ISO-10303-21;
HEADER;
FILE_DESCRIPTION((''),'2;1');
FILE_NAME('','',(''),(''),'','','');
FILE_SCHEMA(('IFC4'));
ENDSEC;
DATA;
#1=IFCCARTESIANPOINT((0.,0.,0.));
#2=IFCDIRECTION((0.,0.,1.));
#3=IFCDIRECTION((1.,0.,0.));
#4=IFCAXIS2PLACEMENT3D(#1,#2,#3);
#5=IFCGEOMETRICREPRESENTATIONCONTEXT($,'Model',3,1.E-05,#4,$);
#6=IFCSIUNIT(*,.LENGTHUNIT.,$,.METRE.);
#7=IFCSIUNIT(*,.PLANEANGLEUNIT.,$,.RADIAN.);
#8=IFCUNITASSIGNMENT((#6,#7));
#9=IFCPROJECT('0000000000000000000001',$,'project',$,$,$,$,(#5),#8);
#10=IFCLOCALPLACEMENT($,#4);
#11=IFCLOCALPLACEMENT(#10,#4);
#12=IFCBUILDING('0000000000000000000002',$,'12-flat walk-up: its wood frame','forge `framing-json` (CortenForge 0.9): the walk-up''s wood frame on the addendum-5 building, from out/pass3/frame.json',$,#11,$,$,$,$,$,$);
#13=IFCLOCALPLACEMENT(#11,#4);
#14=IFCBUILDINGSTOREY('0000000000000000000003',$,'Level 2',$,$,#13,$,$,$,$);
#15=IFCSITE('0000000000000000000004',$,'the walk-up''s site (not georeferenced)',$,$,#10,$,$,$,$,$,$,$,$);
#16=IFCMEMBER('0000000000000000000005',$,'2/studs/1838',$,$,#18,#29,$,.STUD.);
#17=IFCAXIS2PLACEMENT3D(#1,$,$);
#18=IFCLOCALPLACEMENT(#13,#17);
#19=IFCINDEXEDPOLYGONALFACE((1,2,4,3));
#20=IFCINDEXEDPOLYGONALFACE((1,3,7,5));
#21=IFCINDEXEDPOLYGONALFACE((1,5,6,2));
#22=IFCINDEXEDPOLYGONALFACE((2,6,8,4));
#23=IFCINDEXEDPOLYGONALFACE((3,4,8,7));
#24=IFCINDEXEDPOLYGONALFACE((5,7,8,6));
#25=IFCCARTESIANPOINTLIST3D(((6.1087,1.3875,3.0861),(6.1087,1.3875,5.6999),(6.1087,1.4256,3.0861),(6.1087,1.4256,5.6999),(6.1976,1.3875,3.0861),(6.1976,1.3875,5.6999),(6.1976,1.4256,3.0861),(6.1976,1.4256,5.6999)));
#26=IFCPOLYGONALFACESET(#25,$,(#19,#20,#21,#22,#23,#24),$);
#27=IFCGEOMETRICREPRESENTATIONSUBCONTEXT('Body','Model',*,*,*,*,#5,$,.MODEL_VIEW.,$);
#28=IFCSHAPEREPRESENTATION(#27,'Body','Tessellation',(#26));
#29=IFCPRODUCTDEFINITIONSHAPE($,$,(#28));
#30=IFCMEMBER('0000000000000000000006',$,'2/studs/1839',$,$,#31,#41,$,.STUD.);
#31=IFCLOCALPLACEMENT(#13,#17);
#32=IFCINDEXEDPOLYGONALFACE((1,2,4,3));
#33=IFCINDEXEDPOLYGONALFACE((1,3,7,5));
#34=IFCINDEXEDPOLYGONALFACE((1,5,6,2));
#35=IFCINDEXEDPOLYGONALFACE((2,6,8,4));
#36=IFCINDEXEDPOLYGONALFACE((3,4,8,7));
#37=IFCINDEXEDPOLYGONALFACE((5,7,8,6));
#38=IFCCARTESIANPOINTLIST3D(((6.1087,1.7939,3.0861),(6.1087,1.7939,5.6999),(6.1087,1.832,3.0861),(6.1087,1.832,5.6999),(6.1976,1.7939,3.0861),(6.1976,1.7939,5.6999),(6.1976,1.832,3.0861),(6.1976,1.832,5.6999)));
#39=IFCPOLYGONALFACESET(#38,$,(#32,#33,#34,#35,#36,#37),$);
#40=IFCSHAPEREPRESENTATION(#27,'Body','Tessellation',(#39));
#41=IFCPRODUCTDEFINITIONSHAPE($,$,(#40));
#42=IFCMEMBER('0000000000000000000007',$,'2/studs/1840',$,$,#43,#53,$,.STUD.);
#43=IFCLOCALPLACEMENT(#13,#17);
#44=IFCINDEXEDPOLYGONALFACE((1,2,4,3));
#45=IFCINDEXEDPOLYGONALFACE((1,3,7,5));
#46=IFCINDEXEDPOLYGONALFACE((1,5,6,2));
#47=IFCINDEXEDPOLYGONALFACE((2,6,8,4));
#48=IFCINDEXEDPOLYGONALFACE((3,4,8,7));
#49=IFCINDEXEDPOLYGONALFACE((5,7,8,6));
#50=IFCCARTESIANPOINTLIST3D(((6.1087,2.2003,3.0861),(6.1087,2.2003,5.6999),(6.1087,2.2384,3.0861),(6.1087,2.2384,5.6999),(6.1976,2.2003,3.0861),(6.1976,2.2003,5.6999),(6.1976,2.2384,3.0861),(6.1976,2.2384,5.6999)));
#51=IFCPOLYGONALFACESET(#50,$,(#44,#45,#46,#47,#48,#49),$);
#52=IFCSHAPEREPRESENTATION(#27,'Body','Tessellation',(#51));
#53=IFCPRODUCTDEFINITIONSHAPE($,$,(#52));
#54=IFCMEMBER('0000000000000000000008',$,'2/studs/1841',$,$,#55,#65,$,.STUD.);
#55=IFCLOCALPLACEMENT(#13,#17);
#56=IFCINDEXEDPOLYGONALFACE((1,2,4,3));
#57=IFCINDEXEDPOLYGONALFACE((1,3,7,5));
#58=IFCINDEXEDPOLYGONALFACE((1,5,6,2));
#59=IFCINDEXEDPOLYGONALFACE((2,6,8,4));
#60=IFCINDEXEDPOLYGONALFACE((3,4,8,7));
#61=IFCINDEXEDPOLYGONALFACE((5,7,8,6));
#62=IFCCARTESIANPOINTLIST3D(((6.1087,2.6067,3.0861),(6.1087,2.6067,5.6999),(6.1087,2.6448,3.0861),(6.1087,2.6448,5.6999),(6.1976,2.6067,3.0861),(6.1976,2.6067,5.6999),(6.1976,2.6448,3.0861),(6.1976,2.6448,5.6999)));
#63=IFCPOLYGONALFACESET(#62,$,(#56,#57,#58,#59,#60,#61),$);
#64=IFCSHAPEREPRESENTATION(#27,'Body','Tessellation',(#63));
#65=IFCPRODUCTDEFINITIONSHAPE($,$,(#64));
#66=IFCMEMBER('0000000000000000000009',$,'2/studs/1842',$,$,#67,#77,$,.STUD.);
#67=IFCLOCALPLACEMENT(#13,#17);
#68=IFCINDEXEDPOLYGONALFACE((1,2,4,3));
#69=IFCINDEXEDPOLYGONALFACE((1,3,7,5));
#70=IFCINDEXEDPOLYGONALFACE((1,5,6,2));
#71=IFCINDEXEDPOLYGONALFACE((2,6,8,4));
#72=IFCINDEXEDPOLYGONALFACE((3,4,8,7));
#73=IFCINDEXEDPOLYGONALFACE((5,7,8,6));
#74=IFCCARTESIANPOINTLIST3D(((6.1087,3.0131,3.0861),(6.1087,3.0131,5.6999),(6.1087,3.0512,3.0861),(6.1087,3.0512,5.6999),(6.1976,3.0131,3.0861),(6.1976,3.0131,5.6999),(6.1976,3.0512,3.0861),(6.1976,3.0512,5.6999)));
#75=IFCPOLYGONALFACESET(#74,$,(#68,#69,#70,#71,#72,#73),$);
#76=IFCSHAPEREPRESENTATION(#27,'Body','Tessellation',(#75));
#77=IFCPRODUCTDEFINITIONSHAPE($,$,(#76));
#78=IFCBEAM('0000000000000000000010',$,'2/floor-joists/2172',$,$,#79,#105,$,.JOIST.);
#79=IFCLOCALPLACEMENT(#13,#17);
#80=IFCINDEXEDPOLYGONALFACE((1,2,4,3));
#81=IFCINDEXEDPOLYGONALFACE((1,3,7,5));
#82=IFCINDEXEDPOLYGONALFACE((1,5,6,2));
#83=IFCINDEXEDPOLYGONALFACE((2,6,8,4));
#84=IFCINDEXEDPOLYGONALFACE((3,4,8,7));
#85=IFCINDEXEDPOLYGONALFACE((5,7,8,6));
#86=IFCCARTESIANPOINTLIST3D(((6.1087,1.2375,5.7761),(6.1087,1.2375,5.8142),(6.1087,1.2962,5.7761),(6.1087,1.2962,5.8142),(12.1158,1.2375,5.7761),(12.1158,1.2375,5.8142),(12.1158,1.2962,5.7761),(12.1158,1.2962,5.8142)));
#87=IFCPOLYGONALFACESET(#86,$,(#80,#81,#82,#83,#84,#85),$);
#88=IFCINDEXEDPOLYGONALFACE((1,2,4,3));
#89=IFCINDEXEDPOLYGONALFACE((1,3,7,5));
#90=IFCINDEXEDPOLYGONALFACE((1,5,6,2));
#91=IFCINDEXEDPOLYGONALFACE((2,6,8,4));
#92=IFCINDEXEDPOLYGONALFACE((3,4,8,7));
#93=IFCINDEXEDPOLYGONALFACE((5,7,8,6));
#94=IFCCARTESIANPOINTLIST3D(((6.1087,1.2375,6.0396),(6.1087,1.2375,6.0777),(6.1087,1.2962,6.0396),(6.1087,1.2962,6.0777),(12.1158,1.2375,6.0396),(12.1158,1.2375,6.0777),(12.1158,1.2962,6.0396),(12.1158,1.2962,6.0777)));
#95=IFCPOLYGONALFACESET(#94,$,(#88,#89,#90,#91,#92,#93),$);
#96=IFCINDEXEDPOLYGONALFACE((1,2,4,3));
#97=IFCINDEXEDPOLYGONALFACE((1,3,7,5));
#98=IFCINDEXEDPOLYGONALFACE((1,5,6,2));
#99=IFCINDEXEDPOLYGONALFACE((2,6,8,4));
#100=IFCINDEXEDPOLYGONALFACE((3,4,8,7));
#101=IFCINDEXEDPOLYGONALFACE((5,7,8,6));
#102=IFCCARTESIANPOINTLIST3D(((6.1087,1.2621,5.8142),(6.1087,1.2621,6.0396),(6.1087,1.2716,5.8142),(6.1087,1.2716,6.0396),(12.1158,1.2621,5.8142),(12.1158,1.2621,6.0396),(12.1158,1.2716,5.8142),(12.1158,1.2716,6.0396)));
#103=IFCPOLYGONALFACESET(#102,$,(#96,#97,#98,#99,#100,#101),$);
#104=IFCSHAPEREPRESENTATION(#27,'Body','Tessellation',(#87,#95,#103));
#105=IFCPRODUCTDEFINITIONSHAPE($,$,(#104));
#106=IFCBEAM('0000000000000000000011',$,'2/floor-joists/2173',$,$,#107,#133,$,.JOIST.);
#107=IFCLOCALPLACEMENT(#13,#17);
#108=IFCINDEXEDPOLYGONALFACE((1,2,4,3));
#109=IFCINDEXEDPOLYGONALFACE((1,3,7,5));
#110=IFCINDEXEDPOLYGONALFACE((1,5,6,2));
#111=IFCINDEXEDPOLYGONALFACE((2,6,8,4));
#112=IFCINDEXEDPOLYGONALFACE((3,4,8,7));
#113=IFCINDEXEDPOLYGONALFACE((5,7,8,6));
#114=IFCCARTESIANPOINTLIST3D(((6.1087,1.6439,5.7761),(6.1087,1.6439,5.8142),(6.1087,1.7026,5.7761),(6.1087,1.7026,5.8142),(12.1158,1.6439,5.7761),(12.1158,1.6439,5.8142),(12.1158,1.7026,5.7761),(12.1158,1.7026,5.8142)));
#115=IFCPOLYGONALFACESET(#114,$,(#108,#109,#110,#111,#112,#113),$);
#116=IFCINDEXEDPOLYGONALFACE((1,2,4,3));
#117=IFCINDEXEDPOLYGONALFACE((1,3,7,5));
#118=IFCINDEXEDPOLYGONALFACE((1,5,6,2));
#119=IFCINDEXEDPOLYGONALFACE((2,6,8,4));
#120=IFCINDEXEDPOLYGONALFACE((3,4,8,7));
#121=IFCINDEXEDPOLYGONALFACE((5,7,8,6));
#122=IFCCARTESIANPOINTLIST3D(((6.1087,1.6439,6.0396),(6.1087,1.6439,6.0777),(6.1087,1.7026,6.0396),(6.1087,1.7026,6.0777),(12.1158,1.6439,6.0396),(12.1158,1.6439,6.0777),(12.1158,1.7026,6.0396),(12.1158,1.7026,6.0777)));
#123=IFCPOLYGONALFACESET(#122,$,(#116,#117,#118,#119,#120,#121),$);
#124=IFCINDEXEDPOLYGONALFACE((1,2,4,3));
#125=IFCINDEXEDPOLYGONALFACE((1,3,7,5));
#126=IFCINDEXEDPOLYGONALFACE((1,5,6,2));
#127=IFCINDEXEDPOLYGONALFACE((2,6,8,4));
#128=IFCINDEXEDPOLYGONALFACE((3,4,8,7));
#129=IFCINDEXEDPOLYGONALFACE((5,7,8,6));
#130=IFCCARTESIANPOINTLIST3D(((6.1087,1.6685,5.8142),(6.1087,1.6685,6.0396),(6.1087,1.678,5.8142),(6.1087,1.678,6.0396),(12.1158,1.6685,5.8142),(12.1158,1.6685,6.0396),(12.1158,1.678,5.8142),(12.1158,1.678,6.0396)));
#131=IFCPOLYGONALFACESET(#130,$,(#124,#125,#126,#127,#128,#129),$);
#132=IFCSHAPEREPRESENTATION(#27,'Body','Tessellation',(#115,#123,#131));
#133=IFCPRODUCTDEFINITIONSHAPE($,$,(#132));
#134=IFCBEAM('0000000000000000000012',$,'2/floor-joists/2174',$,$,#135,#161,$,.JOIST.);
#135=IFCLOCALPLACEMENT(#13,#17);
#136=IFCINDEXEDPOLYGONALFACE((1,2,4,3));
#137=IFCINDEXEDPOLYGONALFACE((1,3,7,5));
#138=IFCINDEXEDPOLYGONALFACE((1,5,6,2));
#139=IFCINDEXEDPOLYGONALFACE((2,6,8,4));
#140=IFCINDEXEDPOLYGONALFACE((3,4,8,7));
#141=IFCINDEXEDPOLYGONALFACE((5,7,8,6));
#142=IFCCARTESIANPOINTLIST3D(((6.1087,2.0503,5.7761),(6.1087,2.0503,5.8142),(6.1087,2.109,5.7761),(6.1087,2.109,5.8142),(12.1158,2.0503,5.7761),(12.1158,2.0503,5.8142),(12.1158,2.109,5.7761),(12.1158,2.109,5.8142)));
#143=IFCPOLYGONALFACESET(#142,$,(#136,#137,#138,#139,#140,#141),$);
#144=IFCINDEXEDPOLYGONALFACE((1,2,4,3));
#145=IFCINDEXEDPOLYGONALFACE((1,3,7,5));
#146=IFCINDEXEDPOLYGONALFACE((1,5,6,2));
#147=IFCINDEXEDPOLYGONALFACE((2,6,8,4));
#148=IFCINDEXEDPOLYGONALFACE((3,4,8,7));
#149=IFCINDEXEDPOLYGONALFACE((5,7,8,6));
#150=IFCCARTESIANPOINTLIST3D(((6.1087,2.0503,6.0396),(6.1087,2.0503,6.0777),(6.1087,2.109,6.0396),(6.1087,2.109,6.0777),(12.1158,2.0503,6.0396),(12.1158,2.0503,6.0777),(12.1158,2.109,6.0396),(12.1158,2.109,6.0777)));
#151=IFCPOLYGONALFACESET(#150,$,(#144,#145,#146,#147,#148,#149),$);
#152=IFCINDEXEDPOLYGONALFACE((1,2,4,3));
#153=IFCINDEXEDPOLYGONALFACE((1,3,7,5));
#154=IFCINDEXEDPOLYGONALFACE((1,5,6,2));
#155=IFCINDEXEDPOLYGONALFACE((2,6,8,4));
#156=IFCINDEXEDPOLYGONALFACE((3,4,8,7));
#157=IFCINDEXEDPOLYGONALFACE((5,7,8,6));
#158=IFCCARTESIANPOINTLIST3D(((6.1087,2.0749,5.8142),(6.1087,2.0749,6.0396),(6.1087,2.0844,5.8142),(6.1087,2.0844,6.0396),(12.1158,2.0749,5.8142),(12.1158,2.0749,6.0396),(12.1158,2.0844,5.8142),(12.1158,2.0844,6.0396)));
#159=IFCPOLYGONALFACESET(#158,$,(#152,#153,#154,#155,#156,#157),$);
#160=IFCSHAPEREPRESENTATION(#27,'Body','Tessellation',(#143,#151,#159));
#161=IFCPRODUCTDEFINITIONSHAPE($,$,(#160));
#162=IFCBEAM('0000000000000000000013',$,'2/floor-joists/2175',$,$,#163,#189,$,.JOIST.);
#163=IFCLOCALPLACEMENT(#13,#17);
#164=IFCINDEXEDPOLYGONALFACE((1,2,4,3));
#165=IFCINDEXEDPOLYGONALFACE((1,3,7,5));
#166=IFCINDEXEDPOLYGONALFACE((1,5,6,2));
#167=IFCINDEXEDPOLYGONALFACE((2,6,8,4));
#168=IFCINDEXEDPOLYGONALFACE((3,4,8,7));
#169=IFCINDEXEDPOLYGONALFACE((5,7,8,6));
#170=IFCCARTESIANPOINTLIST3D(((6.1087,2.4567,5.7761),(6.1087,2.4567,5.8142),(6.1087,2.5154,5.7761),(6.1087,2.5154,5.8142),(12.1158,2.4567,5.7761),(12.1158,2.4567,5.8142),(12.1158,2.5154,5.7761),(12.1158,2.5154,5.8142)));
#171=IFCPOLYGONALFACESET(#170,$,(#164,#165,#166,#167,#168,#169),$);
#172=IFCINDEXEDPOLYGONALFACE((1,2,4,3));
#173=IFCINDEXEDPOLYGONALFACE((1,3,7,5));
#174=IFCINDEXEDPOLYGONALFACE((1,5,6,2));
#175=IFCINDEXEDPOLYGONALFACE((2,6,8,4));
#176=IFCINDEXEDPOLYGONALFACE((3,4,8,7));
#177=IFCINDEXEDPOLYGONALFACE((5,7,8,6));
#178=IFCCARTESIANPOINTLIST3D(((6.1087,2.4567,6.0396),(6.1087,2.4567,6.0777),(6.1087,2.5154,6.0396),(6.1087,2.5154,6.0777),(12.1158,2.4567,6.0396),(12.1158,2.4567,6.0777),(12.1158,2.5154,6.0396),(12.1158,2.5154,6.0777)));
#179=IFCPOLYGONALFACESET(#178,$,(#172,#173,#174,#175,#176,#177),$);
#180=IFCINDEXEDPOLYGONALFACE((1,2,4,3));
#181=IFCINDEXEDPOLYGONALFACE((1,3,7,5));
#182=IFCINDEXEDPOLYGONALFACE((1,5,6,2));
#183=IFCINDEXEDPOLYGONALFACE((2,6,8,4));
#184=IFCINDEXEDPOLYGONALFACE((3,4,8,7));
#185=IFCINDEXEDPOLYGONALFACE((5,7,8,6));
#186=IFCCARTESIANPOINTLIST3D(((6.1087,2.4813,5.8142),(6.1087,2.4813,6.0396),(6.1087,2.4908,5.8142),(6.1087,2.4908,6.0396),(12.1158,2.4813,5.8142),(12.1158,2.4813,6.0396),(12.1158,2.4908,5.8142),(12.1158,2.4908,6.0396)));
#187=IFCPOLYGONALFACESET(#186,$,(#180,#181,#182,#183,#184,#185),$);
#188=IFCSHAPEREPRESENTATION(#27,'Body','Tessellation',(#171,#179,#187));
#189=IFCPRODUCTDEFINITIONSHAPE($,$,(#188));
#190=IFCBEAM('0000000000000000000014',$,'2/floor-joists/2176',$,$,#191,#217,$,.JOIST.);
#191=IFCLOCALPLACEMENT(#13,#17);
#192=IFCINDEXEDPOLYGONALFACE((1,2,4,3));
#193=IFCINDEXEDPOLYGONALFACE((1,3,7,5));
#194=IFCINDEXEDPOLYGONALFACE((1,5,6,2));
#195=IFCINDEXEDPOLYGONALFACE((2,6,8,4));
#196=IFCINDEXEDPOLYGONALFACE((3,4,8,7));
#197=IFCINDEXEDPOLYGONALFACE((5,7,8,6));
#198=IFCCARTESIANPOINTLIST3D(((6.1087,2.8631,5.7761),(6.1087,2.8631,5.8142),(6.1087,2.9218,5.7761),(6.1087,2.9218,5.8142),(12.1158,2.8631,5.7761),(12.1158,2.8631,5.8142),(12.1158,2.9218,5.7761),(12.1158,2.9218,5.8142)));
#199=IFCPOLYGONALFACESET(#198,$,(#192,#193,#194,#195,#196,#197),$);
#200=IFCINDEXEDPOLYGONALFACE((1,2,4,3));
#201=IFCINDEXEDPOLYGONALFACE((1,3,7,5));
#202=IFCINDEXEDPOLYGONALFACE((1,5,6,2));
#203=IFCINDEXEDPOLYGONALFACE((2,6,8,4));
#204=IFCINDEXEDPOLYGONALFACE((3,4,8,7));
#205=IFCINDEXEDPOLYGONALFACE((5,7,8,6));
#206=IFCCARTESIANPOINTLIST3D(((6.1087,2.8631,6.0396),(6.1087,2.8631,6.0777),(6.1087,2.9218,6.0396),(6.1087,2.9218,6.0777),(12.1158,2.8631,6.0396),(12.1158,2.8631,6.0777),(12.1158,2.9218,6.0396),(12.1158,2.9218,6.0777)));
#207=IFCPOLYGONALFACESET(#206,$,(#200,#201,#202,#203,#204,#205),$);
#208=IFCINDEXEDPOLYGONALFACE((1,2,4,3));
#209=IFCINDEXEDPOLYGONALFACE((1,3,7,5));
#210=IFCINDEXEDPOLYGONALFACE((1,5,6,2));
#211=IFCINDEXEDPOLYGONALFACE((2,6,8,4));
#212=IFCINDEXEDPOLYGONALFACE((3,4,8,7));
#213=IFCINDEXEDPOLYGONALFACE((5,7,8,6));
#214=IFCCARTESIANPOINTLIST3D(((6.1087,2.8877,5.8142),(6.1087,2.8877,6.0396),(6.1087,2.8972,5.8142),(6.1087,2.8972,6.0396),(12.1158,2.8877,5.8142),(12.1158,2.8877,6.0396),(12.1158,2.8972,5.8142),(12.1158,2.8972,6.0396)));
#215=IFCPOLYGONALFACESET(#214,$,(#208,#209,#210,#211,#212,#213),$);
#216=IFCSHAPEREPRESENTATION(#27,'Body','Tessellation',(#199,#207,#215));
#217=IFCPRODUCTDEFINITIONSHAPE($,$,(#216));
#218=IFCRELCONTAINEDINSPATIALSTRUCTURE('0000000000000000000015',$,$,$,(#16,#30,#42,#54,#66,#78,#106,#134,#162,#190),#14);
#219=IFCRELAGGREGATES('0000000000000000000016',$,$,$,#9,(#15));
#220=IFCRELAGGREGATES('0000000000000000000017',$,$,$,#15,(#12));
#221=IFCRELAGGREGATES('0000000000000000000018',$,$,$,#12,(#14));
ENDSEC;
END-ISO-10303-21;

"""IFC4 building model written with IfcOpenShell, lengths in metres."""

from ifc_helpers import new_model, si_unit, frame, frame_2d, origin, origin_with_axes, place, context, subcontext, project, spatial, rectangle, extrude, element, save


model = new_model("IFC4")

# Units and contexts
model_context = context("Model", 3, precision=1e-05, world=origin_with_axes())
body_context = subcontext(model_context, "Body", "Model", "MODEL_VIEW")
ifc_project = project(units=[si_unit("LENGTHUNIT", "METRE"), si_unit("PLANEANGLEUNIT", "RADIAN")], contexts=[model_context])

# Site, building, storey
site_placement = place(None, origin_with_axes())
site = spatial("IfcSite", under=ifc_project, at=site_placement, Name="the walk-up's site (not georeferenced)")
building_placement = place(site_placement, origin_with_axes())
building = spatial("IfcBuilding", under=site, at=building_placement, Name="12-flat walk-up: its wood frame", Description="forge `framing-json` (CortenForge 0.9): the walk-up's wood frame on the addendum-5 building, from out/pass3/frame.json")
storey_placement = place(building_placement, origin_with_axes())
storey = spatial("IfcBuildingStorey", under=building, at=storey_placement, Name="Level 2")

# Members
member_1_placement = place(storey_placement, frame((6.1087, 1.3875, 3.0861), z_axis=(0.0, 0.0, 1.0), x_axis=(1.0, 0.0, 0.0)))
element("IfcMember", 1, at=member_1_placement, inside=storey, Name="2/studs/1838", PredefinedType="STUD", context=body_context, shape_type="SweptSolid", body=[
    extrude(rectangle(XDim=0.0889, YDim=0.0381, at=frame_2d((0.0445, 0.0191))), origin(), (0.0, 0.0, 1.0), 2.6138),
])
member_2_placement = place(storey_placement, frame((6.1087, 1.7939, 3.0861), z_axis=(0.0, 0.0, 1.0), x_axis=(1.0, 0.0, 0.0)))
element("IfcMember", 2, at=member_2_placement, inside=storey, Name="2/studs/1839", PredefinedType="STUD", context=body_context, shape_type="SweptSolid", body=[
    extrude(rectangle(XDim=0.0889, YDim=0.0381, at=frame_2d((0.0445, 0.019))), origin(), (0.0, 0.0, 1.0), 2.6138),
])
for number, where, z_axis, x_axis, name in (
    (3, (6.1087, 2.2003, 3.0861), (0.0, 0.0, 1.0), (1.0, 0.0, 0.0), "2/studs/1840"),
    (4, (6.1087, 2.6067, 3.0861), (0.0, 0.0, 1.0), (1.0, 0.0, 0.0), "2/studs/1841"),
    (5, (6.1087, 3.0131, 3.0861), (0.0, 0.0, 1.0), (1.0, 0.0, 0.0), "2/studs/1842"),
):
    element("IfcMember", number, at=place(storey_placement, frame(where, z_axis=z_axis, x_axis=x_axis)), inside=storey, Name=name, PredefinedType="STUD", context=body_context, shape_type="SweptSolid", body=[
        extrude(rectangle(XDim=0.0889, YDim=0.0381, at=frame_2d((0.0445, 0.0191))), origin(), (0.0, 0.0, 1.0), 2.6138),
    ])

# Beams
beam_1_placement = place(storey_placement, frame((6.1087, 1.2375, 5.7761), z_axis=(0.0, 0.0, 1.0), x_axis=(1.0, 0.0, 0.0)))
element("IfcBeam", 6, at=beam_1_placement, inside=storey, Name="2/floor-joists/2172", PredefinedType="JOIST", context=body_context, shape_type="SweptSolid", body=[
    extrude(rectangle(XDim=6.0071, YDim=0.0587, at=frame_2d((3.0036, 0.0294))), origin(), (0.0, 0.0, 1.0), 0.0381),
    extrude(rectangle(XDim=6.0071, YDim=0.0587, at=frame_2d((3.0036, 0.0294))), frame((0.0, 0.0, 0.2635)), (0.0, 0.0, 1.0), 0.0381),
    extrude(rectangle(XDim=6.0071, YDim=0.0095, at=frame_2d((3.0036, 0.0048))), frame((0.0, 0.0246, 0.0381)), (0.0, 0.0, 1.0), 0.2254),
])
beam_2_placement = place(storey_placement, frame((6.1087, 1.6439, 5.7761), z_axis=(0.0, 0.0, 1.0), x_axis=(1.0, 0.0, 0.0)))
element("IfcBeam", 7, at=beam_2_placement, inside=storey, Name="2/floor-joists/2173", PredefinedType="JOIST", context=body_context, shape_type="SweptSolid", body=[
    extrude(rectangle(XDim=6.0071, YDim=0.0587, at=frame_2d((3.0036, 0.0294))), origin(), (0.0, 0.0, 1.0), 0.0381),
    extrude(rectangle(XDim=6.0071, YDim=0.0587, at=frame_2d((3.0036, 0.0294))), frame((0.0, 0.0, 0.2635)), (0.0, 0.0, 1.0), 0.0381),
    extrude(rectangle(XDim=6.0071, YDim=0.0095, at=frame_2d((3.0036, 0.0048))), frame((0.0, 0.0246, 0.0381)), (0.0, 0.0, 1.0), 0.2254),
])
beam_3_placement = place(storey_placement, frame((6.1087, 2.0503, 5.7761), z_axis=(0.0, 0.0, 1.0), x_axis=(1.0, 0.0, 0.0)))
element("IfcBeam", 8, at=beam_3_placement, inside=storey, Name="2/floor-joists/2174", PredefinedType="JOIST", context=body_context, shape_type="SweptSolid", body=[
    extrude(rectangle(XDim=6.0071, YDim=0.0587, at=frame_2d((3.0036, 0.0294))), origin(), (0.0, 0.0, 1.0), 0.0381),
    extrude(rectangle(XDim=6.0071, YDim=0.0587, at=frame_2d((3.0036, 0.0294))), frame((0.0, 0.0, 0.2635)), (0.0, 0.0, 1.0), 0.0381),
    extrude(rectangle(XDim=6.0071, YDim=0.0095, at=frame_2d((3.0036, 0.0048))), frame((0.0, 0.0246, 0.0381)), (0.0, 0.0, 1.0), 0.2254),
])
beam_4_placement = place(storey_placement, frame((6.1087, 2.4567, 5.7761), z_axis=(0.0, 0.0, 1.0), x_axis=(1.0, 0.0, 0.0)))
element("IfcBeam", 9, at=beam_4_placement, inside=storey, Name="2/floor-joists/2175", PredefinedType="JOIST", context=body_context, shape_type="SweptSolid", body=[
    extrude(rectangle(XDim=6.0071, YDim=0.0587, at=frame_2d((3.0036, 0.0294))), origin(), (0.0, 0.0, 1.0), 0.0381),
    extrude(rectangle(XDim=6.0071, YDim=0.0587, at=frame_2d((3.0036, 0.0294))), frame((0.0, 0.0, 0.2635)), (0.0, 0.0, 1.0), 0.0381),
    extrude(rectangle(XDim=6.0071, YDim=0.0095, at=frame_2d((3.0036, 0.0048))), frame((0.0, 0.0246, 0.0381)), (0.0, 0.0, 1.0), 0.2254),
])
for number, where, z_axis, x_axis, name in (
    (10, (6.1087, 2.8631, 5.7761), (0.0, 0.0, 1.0), (1.0, 0.0, 0.0), "2/floor-joists/2176"),
):
    element("IfcBeam", number, at=place(storey_placement, frame(where, z_axis=z_axis, x_axis=x_axis)), inside=storey, Name=name, PredefinedType="JOIST", context=body_context, shape_type="SweptSolid", body=[
        extrude(rectangle(XDim=6.0071, YDim=0.0587, at=frame_2d((3.0036, 0.0294))), origin(), (0.0, 0.0, 1.0), 0.0381),
        extrude(rectangle(XDim=6.0071, YDim=0.0587, at=frame_2d((3.0036, 0.0294))), frame((0.0, 0.0, 0.2635)), (0.0, 0.0, 1.0), 0.0381),
        extrude(rectangle(XDim=6.0071, YDim=0.0095, at=frame_2d((3.0036, 0.0048))), frame((0.0, 0.0246, 0.0381)), (0.0, 0.0, 1.0), 0.2254),
    ])

save(model, "model.ifc")
